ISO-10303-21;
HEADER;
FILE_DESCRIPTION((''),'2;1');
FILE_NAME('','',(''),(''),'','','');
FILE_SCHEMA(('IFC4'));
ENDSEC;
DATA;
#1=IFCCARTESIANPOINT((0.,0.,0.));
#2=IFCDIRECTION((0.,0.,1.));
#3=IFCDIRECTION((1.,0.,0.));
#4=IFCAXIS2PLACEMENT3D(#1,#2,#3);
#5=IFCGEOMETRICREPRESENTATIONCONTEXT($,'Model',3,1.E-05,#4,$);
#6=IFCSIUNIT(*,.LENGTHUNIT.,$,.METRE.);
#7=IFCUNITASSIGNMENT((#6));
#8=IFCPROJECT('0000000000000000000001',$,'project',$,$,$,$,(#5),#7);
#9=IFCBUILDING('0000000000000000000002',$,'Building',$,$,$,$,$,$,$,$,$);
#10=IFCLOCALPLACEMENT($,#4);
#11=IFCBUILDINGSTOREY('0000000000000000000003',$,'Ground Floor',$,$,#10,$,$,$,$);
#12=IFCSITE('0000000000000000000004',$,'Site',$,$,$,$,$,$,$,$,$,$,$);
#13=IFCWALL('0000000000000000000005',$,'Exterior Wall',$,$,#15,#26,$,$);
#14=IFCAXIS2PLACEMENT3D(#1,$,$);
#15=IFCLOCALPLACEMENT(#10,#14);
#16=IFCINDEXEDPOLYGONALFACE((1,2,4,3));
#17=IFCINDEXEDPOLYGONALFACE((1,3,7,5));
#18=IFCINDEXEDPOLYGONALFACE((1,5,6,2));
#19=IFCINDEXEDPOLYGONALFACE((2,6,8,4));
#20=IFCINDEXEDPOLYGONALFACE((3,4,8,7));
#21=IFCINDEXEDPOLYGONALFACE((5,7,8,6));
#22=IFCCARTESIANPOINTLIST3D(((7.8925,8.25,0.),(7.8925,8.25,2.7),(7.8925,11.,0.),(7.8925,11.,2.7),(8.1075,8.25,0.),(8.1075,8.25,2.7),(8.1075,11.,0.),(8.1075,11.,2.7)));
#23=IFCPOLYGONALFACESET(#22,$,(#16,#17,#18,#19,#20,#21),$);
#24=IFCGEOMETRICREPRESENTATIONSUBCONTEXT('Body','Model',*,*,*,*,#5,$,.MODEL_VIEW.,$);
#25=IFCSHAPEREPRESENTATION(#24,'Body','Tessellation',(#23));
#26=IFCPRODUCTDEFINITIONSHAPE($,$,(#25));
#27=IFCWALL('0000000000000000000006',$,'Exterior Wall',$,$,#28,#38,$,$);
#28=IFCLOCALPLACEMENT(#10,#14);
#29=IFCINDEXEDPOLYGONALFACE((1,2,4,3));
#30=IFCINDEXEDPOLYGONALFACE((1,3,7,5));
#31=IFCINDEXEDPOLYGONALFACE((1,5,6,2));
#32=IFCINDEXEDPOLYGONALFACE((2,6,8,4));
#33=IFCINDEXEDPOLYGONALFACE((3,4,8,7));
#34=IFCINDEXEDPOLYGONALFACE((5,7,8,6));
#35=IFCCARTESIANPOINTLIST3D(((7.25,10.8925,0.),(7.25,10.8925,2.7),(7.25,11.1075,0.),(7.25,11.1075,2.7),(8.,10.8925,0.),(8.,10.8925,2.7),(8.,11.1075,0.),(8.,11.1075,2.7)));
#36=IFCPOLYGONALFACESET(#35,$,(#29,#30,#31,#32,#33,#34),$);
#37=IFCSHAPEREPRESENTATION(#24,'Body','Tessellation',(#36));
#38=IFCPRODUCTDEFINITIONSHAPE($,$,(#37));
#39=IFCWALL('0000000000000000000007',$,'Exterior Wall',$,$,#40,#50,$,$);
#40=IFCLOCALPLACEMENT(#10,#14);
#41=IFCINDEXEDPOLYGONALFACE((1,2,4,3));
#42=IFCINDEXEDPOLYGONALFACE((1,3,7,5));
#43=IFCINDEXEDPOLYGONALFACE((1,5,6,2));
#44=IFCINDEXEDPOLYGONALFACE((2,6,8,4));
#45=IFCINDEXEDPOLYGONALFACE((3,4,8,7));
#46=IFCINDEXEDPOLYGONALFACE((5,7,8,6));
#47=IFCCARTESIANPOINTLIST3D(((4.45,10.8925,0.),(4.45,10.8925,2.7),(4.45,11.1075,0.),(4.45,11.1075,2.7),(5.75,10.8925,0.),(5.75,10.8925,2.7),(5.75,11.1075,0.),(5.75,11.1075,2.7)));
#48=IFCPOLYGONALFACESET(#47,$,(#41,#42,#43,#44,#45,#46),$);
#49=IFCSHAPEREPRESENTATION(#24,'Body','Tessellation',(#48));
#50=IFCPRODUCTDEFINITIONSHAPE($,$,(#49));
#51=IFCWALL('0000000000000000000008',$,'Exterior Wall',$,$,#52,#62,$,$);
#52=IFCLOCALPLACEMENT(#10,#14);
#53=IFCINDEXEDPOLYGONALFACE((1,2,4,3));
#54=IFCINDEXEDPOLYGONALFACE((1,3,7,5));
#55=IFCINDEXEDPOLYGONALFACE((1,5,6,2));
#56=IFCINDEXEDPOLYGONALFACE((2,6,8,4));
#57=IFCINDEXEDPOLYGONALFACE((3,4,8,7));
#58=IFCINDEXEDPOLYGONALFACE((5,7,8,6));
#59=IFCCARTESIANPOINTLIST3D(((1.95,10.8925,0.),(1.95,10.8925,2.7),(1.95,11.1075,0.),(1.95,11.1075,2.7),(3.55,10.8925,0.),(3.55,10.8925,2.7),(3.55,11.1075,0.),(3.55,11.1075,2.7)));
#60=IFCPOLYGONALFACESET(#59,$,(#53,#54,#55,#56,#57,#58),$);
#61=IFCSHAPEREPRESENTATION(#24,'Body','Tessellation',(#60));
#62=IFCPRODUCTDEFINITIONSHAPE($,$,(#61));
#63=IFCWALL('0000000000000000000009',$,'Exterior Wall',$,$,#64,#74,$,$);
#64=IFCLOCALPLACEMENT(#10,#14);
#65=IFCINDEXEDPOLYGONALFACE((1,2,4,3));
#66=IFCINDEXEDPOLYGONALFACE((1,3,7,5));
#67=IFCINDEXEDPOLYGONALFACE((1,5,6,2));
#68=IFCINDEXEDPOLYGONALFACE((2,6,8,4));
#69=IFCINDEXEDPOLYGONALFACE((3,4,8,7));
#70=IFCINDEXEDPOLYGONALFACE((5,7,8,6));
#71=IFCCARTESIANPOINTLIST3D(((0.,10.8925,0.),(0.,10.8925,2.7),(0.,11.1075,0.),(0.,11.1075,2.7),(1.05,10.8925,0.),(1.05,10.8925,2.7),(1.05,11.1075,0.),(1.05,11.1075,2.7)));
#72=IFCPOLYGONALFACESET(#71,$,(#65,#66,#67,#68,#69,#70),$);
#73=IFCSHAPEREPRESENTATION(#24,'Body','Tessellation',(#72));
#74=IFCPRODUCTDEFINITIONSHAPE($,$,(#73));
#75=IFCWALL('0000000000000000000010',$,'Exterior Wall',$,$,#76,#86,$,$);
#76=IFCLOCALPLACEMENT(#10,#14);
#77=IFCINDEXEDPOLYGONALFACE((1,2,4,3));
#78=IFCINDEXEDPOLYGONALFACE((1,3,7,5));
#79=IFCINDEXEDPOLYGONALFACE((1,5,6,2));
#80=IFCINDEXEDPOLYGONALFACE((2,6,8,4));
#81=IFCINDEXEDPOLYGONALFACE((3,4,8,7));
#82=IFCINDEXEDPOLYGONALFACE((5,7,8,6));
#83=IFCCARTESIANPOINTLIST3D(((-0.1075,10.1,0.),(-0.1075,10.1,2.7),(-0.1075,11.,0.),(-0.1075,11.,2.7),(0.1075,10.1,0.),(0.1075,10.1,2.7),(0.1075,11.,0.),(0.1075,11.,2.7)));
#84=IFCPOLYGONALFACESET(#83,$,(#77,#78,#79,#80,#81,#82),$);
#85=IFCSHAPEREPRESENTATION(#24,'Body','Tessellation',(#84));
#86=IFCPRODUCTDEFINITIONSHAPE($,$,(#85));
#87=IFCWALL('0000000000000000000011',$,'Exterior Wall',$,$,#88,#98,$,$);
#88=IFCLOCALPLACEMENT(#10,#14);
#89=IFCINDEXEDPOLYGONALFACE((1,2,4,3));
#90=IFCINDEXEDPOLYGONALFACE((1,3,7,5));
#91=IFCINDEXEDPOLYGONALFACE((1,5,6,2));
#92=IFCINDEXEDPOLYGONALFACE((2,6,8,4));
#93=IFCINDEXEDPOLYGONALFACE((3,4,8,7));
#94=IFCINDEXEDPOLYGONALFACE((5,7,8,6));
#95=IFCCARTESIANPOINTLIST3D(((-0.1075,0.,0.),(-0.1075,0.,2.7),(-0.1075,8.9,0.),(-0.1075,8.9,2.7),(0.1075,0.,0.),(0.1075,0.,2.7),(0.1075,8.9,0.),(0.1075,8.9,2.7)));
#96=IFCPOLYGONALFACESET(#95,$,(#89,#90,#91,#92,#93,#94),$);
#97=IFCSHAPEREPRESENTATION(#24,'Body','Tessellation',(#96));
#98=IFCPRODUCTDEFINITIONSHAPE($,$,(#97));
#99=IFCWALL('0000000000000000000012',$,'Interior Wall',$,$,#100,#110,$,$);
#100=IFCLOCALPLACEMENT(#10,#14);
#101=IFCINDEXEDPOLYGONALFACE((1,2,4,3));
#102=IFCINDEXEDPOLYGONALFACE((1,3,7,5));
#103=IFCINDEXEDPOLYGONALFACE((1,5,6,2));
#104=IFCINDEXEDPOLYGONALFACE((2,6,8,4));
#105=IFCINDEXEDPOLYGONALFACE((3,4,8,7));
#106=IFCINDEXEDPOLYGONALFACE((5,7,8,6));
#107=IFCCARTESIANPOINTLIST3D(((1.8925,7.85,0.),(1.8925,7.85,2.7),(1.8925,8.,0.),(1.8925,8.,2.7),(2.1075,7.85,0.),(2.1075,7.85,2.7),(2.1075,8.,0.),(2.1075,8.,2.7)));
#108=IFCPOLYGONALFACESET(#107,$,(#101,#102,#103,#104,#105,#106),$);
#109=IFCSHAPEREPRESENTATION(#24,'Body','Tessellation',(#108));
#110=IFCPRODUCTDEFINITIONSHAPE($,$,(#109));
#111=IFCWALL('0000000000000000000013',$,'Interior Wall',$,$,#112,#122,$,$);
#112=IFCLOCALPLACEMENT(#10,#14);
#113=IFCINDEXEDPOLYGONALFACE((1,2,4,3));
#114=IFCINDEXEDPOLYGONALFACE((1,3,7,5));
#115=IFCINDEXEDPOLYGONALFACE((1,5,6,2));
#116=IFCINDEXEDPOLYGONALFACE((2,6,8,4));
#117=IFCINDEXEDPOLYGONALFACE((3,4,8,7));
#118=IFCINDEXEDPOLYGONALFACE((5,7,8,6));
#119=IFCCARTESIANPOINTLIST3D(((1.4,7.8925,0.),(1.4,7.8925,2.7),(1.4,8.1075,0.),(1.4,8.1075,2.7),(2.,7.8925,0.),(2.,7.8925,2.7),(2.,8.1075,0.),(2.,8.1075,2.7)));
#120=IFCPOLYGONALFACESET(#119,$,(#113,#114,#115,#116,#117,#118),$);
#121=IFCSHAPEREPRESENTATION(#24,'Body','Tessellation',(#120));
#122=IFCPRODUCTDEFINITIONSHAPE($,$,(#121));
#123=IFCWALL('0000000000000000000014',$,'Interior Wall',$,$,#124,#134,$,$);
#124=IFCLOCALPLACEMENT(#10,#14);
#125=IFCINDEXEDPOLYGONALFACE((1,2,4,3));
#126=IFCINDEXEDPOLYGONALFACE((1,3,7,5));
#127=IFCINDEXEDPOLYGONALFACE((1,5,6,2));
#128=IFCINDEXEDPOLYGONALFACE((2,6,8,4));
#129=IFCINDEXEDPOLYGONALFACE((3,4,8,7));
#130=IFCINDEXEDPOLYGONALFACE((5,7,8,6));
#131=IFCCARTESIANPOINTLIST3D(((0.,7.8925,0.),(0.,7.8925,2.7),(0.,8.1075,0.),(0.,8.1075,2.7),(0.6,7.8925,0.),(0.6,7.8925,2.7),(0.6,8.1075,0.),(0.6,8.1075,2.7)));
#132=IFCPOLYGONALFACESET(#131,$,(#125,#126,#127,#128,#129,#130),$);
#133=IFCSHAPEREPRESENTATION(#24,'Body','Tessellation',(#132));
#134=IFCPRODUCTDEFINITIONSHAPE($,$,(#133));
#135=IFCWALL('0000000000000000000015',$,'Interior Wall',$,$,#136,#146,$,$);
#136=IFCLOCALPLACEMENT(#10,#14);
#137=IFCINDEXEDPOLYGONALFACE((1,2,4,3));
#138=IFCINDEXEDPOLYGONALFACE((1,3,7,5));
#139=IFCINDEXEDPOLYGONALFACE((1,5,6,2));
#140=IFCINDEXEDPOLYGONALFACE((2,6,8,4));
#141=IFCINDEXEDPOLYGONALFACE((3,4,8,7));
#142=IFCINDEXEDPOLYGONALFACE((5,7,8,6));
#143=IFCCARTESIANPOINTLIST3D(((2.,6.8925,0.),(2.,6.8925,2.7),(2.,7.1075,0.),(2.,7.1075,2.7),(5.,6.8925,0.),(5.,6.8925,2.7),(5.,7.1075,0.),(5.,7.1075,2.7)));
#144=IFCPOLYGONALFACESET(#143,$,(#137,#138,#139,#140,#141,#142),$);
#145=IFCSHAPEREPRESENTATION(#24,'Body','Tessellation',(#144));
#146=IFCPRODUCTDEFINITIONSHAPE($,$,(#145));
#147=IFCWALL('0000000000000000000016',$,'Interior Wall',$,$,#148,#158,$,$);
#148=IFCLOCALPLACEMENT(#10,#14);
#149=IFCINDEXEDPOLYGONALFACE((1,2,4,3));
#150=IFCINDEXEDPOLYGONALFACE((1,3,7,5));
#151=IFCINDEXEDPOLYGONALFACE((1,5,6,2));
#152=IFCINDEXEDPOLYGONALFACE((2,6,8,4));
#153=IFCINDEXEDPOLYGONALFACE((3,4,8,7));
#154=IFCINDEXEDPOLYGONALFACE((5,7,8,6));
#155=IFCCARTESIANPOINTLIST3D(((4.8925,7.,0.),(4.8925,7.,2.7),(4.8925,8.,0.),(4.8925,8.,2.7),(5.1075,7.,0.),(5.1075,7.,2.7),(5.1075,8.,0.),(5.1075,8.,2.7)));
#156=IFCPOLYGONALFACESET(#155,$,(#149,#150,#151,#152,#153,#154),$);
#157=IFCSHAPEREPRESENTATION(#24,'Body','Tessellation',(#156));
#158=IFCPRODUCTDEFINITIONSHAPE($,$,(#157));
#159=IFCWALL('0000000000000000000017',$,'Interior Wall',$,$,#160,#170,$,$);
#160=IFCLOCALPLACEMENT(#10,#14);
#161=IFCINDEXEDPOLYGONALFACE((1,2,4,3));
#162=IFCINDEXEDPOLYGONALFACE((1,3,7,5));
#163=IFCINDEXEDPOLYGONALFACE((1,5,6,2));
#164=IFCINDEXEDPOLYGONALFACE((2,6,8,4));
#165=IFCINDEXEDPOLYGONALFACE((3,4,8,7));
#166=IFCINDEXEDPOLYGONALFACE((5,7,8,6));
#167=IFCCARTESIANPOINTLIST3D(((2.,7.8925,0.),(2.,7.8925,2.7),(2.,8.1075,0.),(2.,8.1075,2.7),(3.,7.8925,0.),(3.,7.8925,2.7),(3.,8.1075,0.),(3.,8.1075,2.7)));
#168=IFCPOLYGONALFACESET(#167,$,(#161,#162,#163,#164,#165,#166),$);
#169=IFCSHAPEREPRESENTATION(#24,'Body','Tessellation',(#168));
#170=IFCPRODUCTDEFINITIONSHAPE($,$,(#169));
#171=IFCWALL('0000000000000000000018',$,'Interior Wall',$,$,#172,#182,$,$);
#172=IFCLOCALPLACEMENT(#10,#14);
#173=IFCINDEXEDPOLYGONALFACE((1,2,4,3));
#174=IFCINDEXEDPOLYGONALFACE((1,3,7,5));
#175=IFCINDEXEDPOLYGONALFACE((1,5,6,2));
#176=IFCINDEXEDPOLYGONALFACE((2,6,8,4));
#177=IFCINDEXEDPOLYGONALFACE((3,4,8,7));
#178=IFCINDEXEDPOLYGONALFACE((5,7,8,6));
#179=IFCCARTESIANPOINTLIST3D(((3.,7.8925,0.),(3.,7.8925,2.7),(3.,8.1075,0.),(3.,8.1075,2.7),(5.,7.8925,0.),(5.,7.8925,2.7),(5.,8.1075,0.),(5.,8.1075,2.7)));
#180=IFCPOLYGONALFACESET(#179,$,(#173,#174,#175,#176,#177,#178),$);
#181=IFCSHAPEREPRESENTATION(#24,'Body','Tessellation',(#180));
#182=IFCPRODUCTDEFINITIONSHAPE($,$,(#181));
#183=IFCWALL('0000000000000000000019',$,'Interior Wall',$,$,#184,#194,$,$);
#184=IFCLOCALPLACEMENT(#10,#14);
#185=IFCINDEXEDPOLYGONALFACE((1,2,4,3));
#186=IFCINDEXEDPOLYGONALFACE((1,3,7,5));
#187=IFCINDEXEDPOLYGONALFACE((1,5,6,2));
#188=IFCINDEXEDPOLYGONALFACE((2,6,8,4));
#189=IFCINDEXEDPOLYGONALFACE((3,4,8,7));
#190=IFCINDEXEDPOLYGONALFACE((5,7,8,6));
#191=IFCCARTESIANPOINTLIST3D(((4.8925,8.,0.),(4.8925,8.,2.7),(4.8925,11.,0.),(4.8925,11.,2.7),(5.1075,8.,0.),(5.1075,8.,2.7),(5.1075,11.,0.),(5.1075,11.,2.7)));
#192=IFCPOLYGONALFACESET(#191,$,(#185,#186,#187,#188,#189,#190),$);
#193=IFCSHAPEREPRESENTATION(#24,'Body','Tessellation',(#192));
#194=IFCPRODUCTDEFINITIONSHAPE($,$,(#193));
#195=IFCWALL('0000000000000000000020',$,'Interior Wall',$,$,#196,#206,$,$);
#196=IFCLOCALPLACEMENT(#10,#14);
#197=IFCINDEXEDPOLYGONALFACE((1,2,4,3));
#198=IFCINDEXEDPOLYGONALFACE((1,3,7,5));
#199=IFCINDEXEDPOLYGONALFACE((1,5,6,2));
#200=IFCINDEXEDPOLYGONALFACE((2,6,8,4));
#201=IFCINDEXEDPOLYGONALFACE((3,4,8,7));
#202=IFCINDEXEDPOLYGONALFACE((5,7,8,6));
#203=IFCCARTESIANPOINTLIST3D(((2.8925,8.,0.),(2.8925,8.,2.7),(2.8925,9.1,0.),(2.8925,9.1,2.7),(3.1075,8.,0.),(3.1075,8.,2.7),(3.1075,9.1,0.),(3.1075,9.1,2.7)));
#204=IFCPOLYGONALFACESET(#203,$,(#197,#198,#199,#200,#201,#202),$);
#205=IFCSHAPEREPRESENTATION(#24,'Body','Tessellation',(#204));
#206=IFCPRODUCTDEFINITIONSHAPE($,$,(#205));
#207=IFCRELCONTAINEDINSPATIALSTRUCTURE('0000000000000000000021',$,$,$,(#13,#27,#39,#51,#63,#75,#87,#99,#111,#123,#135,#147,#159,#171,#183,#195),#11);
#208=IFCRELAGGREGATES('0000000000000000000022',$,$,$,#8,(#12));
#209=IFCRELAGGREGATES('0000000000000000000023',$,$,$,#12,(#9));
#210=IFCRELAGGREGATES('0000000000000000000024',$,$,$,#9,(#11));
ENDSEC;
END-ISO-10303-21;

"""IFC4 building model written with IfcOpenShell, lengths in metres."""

from ifc_helpers import new_model, si_unit, frame, origin_with_axes, place, context, subcontext, project, spatial, indexed_curve, outline, extrude, element, save


model = new_model("IFC4")

# Units and contexts
model_context = context("Model", 3, precision=1e-05, world=origin_with_axes())
body_context = subcontext(model_context, "Body", "Model", "MODEL_VIEW")
ifc_project = project(units=[si_unit("LENGTHUNIT", "METRE")], contexts=[model_context])

# Site, building, storey
site = spatial("IfcSite", under=ifc_project, Name="Site")
building = spatial("IfcBuilding", under=site, Name="Building")
storey_placement = place(None, origin_with_axes())
storey = spatial("IfcBuildingStorey", under=building, at=storey_placement, Name="Ground Floor")

# Walls
wall_1_placement = place(storey_placement, frame((8.0, 8.25, 0.0), z_axis=(0.0, 0.0, 1.0), x_axis=(0.0, 1.0, 0.0)))
element("IfcWall", 1, at=wall_1_placement, inside=storey, Name="Exterior Wall", context=body_context, shape_type="SweptSolid", body=[
    extrude(outline(indexed_curve([(0.0, 0.0), (0.0, 0.215), (2.75, 0.215), (2.75, 0.0), (0.0, 0.0)], self_intersect=False)), frame((0.0, -0.1075, 0.0), z_axis=(0.0, 0.0, 1.0), x_axis=(1.0, 0.0, 0.0)), (0.0, 0.0, 1.0), 2.7),
])
wall_2_placement = place(storey_placement, frame((8.0, 11.0, 0.0), z_axis=(0.0, 0.0, 1.0), x_axis=(-1.0, 0.0, 0.0)))
element("IfcWall", 2, at=wall_2_placement, inside=storey, Name="Exterior Wall", context=body_context, shape_type="SweptSolid", body=[
    extrude(outline(indexed_curve([(0.0, 0.0), (0.0, 0.215), (0.75, 0.215), (0.75, 0.0), (0.0, 0.0)], self_intersect=False)), frame((0.0, -0.1075, 0.0), z_axis=(0.0, 0.0, 1.0), x_axis=(1.0, 0.0, 0.0)), (0.0, 0.0, 1.0), 2.7),
])
wall_3_placement = place(storey_placement, frame((5.75, 11.0, 0.0), z_axis=(0.0, 0.0, 1.0), x_axis=(-1.0, 0.0, 0.0)))
element("IfcWall", 3, at=wall_3_placement, inside=storey, Name="Exterior Wall", context=body_context, shape_type="SweptSolid", body=[
    extrude(outline(indexed_curve([(0.0, 0.0), (0.0, 0.215), (1.3, 0.215), (1.3, 0.0), (0.0, 0.0)], self_intersect=False)), frame((0.0, -0.1075, 0.0), z_axis=(0.0, 0.0, 1.0), x_axis=(1.0, 0.0, 0.0)), (0.0, 0.0, 1.0), 2.7),
])
wall_4_placement = place(storey_placement, frame((3.55, 11.0, 0.0), z_axis=(0.0, 0.0, 1.0), x_axis=(-1.0, 0.0, 0.0)))
element("IfcWall", 4, at=wall_4_placement, inside=storey, Name="Exterior Wall", context=body_context, shape_type="SweptSolid", body=[
    extrude(outline(indexed_curve([(0.0, 0.0), (0.0, 0.215), (1.6, 0.215), (1.6, 0.0), (0.0, 0.0)], self_intersect=False)), frame((0.0, -0.1075, 0.0), z_axis=(0.0, 0.0, 1.0), x_axis=(1.0, 0.0, 0.0)), (0.0, 0.0, 1.0), 2.7),
])
wall_5_placement = place(storey_placement, frame((1.05, 11.0, 0.0), z_axis=(0.0, 0.0, 1.0), x_axis=(-1.0, 0.0, 0.0)))
element("IfcWall", 5, at=wall_5_placement, inside=storey, Name="Exterior Wall", context=body_context, shape_type="SweptSolid", body=[
    extrude(outline(indexed_curve([(0.0, 0.0), (0.0, 0.215), (1.05, 0.215), (1.05, 0.0), (0.0, 0.0)], self_intersect=False)), frame((0.0, -0.1075, 0.0), z_axis=(0.0, 0.0, 1.0), x_axis=(1.0, 0.0, 0.0)), (0.0, 0.0, 1.0), 2.7),
])
wall_6_placement = place(storey_placement, frame((0.0, 11.0, 0.0), z_axis=(0.0, 0.0, 1.0), x_axis=(0.0, -1.0, 0.0)))
element("IfcWall", 6, at=wall_6_placement, inside=storey, Name="Exterior Wall", context=body_context, shape_type="SweptSolid", body=[
    extrude(outline(indexed_curve([(0.0, 0.0), (0.0, 0.215), (0.9, 0.215), (0.9, 0.0), (0.0, 0.0)], self_intersect=False)), frame((0.0, -0.1075, 0.0), z_axis=(0.0, 0.0, 1.0), x_axis=(1.0, 0.0, 0.0)), (0.0, 0.0, 1.0), 2.7),
])
wall_7_placement = place(storey_placement, frame((0.0, 8.9, 0.0), z_axis=(0.0, 0.0, 1.0), x_axis=(0.0, -1.0, 0.0)))
element("IfcWall", 7, at=wall_7_placement, inside=storey, Name="Exterior Wall", context=body_context, shape_type="SweptSolid", body=[
    extrude(outline(indexed_curve([(0.0, 0.0), (0.0, 0.215), (8.9, 0.215), (8.9, 0.0), (0.0, 0.0)], self_intersect=False)), frame((0.0, -0.1075, 0.0), z_axis=(0.0, 0.0, 1.0), x_axis=(1.0, 0.0, 0.0)), (0.0, 0.0, 1.0), 2.7),
])
wall_8_placement = place(storey_placement, frame((2.0, 7.85, 0.0), z_axis=(0.0, 0.0, 1.0), x_axis=(0.0, 1.0, 0.0)))
element("IfcWall", 8, at=wall_8_placement, inside=storey, Name="Interior Wall", context=body_context, shape_type="SweptSolid", body=[
    extrude(outline(indexed_curve([(0.0, 0.0), (0.0, 0.215), (0.15, 0.215), (0.15, 0.0), (0.0, 0.0)], self_intersect=False)), frame((0.0, -0.1075, 0.0), z_axis=(0.0, 0.0, 1.0), x_axis=(1.0, 0.0, 0.0)), (0.0, 0.0, 1.0), 2.7),
])
for number, where, z_axis, x_axis, name in (
    (9, (2.0, 8.0, 0.0), (0.0, 0.0, 1.0), (-1.0, 0.0, 0.0), "Interior Wall"),
    (10, (0.6, 8.0, 0.0), (0.0, 0.0, 1.0), (-1.0, 0.0, 0.0), "Interior Wall"),
):
    element("IfcWall", number, at=place(storey_placement, frame(where, z_axis=z_axis, x_axis=x_axis)), inside=storey, Name=name, context=body_context, shape_type="SweptSolid", body=[
        extrude(outline(indexed_curve([(0.0, 0.0), (0.0, 0.215), (0.6, 0.215), (0.6, 0.0), (0.0, 0.0)], self_intersect=False)), frame((0.0, -0.1075, 0.0), z_axis=(0.0, 0.0, 1.0), x_axis=(1.0, 0.0, 0.0)), (0.0, 0.0, 1.0), 2.7),
    ])
wall_9_placement = place(storey_placement, frame((5.0, 7.0, 0.0), z_axis=(0.0, 0.0, 1.0), x_axis=(-1.0, 0.0, 0.0)))
element("IfcWall", 11, at=wall_9_placement, inside=storey, Name="Interior Wall", context=body_context, shape_type="SweptSolid", body=[
    extrude(outline(indexed_curve([(0.0, 0.0), (0.0, 0.215), (3.0, 0.215), (3.0, 0.0), (0.0, 0.0)], self_intersect=False)), frame((0.0, -0.1075, 0.0), z_axis=(0.0, 0.0, 1.0), x_axis=(1.0, 0.0, 0.0)), (0.0, 0.0, 1.0), 2.7),
])
for number, where, z_axis, x_axis, name in (
    (12, (5.0, 7.0, 0.0), (0.0, 0.0, 1.0), (0.0, 1.0, 0.0), "Interior Wall"),
    (13, (3.0, 8.0, 0.0), (0.0, 0.0, 1.0), (-1.0, 0.0, 0.0), "Interior Wall"),
):
    element("IfcWall", number, at=place(storey_placement, frame(where, z_axis=z_axis, x_axis=x_axis)), inside=storey, Name=name, context=body_context, shape_type="SweptSolid", body=[
        extrude(outline(indexed_curve([(0.0, 0.0), (0.0, 0.215), (1.0, 0.215), (1.0, 0.0), (0.0, 0.0)], self_intersect=False)), frame((0.0, -0.1075, 0.0), z_axis=(0.0, 0.0, 1.0), x_axis=(1.0, 0.0, 0.0)), (0.0, 0.0, 1.0), 2.7),
    ])
wall_10_placement = place(storey_placement, frame((5.0, 8.0, 0.0), z_axis=(0.0, 0.0, 1.0), x_axis=(-1.0, 0.0, 0.0)))
element("IfcWall", 14, at=wall_10_placement, inside=storey, Name="Interior Wall", context=body_context, shape_type="SweptSolid", body=[
    extrude(outline(indexed_curve([(0.0, 0.0), (0.0, 0.215), (2.0, 0.215), (2.0, 0.0), (0.0, 0.0)], self_intersect=False)), frame((0.0, -0.1075, 0.0), z_axis=(0.0, 0.0, 1.0), x_axis=(1.0, 0.0, 0.0)), (0.0, 0.0, 1.0), 2.7),
])
wall_11_placement = place(storey_placement, frame((5.0, 11.0, 0.0), z_axis=(0.0, 0.0, 1.0), x_axis=(0.0, -1.0, 0.0)))
element("IfcWall", 15, at=wall_11_placement, inside=storey, Name="Interior Wall", context=body_context, shape_type="SweptSolid", body=[
    extrude(outline(indexed_curve([(0.0, 0.0), (0.0, 0.215), (3.0, 0.215), (3.0, 0.0), (0.0, 0.0)], self_intersect=False)), frame((0.0, -0.1075, 0.0), z_axis=(0.0, 0.0, 1.0), x_axis=(1.0, 0.0, 0.0)), (0.0, 0.0, 1.0), 2.7),
])
for number, where, z_axis, x_axis, name in (
    (16, (3.0, 8.0, 0.0), (0.0, 0.0, 1.0), (0.0, 1.0, 0.0), "Interior Wall"),
):
    element("IfcWall", number, at=place(storey_placement, frame(where, z_axis=z_axis, x_axis=x_axis)), inside=storey, Name=name, context=body_context, shape_type="SweptSolid", body=[
        extrude(outline(indexed_curve([(0.0, 0.0), (0.0, 0.215), (1.1, 0.215), (1.1, 0.0), (0.0, 0.0)], self_intersect=False)), frame((0.0, -0.1075, 0.0), z_axis=(0.0, 0.0, 1.0), x_axis=(1.0, 0.0, 0.0)), (0.0, 0.0, 1.0), 2.7),
    ])

save(model, "model.ifc")
